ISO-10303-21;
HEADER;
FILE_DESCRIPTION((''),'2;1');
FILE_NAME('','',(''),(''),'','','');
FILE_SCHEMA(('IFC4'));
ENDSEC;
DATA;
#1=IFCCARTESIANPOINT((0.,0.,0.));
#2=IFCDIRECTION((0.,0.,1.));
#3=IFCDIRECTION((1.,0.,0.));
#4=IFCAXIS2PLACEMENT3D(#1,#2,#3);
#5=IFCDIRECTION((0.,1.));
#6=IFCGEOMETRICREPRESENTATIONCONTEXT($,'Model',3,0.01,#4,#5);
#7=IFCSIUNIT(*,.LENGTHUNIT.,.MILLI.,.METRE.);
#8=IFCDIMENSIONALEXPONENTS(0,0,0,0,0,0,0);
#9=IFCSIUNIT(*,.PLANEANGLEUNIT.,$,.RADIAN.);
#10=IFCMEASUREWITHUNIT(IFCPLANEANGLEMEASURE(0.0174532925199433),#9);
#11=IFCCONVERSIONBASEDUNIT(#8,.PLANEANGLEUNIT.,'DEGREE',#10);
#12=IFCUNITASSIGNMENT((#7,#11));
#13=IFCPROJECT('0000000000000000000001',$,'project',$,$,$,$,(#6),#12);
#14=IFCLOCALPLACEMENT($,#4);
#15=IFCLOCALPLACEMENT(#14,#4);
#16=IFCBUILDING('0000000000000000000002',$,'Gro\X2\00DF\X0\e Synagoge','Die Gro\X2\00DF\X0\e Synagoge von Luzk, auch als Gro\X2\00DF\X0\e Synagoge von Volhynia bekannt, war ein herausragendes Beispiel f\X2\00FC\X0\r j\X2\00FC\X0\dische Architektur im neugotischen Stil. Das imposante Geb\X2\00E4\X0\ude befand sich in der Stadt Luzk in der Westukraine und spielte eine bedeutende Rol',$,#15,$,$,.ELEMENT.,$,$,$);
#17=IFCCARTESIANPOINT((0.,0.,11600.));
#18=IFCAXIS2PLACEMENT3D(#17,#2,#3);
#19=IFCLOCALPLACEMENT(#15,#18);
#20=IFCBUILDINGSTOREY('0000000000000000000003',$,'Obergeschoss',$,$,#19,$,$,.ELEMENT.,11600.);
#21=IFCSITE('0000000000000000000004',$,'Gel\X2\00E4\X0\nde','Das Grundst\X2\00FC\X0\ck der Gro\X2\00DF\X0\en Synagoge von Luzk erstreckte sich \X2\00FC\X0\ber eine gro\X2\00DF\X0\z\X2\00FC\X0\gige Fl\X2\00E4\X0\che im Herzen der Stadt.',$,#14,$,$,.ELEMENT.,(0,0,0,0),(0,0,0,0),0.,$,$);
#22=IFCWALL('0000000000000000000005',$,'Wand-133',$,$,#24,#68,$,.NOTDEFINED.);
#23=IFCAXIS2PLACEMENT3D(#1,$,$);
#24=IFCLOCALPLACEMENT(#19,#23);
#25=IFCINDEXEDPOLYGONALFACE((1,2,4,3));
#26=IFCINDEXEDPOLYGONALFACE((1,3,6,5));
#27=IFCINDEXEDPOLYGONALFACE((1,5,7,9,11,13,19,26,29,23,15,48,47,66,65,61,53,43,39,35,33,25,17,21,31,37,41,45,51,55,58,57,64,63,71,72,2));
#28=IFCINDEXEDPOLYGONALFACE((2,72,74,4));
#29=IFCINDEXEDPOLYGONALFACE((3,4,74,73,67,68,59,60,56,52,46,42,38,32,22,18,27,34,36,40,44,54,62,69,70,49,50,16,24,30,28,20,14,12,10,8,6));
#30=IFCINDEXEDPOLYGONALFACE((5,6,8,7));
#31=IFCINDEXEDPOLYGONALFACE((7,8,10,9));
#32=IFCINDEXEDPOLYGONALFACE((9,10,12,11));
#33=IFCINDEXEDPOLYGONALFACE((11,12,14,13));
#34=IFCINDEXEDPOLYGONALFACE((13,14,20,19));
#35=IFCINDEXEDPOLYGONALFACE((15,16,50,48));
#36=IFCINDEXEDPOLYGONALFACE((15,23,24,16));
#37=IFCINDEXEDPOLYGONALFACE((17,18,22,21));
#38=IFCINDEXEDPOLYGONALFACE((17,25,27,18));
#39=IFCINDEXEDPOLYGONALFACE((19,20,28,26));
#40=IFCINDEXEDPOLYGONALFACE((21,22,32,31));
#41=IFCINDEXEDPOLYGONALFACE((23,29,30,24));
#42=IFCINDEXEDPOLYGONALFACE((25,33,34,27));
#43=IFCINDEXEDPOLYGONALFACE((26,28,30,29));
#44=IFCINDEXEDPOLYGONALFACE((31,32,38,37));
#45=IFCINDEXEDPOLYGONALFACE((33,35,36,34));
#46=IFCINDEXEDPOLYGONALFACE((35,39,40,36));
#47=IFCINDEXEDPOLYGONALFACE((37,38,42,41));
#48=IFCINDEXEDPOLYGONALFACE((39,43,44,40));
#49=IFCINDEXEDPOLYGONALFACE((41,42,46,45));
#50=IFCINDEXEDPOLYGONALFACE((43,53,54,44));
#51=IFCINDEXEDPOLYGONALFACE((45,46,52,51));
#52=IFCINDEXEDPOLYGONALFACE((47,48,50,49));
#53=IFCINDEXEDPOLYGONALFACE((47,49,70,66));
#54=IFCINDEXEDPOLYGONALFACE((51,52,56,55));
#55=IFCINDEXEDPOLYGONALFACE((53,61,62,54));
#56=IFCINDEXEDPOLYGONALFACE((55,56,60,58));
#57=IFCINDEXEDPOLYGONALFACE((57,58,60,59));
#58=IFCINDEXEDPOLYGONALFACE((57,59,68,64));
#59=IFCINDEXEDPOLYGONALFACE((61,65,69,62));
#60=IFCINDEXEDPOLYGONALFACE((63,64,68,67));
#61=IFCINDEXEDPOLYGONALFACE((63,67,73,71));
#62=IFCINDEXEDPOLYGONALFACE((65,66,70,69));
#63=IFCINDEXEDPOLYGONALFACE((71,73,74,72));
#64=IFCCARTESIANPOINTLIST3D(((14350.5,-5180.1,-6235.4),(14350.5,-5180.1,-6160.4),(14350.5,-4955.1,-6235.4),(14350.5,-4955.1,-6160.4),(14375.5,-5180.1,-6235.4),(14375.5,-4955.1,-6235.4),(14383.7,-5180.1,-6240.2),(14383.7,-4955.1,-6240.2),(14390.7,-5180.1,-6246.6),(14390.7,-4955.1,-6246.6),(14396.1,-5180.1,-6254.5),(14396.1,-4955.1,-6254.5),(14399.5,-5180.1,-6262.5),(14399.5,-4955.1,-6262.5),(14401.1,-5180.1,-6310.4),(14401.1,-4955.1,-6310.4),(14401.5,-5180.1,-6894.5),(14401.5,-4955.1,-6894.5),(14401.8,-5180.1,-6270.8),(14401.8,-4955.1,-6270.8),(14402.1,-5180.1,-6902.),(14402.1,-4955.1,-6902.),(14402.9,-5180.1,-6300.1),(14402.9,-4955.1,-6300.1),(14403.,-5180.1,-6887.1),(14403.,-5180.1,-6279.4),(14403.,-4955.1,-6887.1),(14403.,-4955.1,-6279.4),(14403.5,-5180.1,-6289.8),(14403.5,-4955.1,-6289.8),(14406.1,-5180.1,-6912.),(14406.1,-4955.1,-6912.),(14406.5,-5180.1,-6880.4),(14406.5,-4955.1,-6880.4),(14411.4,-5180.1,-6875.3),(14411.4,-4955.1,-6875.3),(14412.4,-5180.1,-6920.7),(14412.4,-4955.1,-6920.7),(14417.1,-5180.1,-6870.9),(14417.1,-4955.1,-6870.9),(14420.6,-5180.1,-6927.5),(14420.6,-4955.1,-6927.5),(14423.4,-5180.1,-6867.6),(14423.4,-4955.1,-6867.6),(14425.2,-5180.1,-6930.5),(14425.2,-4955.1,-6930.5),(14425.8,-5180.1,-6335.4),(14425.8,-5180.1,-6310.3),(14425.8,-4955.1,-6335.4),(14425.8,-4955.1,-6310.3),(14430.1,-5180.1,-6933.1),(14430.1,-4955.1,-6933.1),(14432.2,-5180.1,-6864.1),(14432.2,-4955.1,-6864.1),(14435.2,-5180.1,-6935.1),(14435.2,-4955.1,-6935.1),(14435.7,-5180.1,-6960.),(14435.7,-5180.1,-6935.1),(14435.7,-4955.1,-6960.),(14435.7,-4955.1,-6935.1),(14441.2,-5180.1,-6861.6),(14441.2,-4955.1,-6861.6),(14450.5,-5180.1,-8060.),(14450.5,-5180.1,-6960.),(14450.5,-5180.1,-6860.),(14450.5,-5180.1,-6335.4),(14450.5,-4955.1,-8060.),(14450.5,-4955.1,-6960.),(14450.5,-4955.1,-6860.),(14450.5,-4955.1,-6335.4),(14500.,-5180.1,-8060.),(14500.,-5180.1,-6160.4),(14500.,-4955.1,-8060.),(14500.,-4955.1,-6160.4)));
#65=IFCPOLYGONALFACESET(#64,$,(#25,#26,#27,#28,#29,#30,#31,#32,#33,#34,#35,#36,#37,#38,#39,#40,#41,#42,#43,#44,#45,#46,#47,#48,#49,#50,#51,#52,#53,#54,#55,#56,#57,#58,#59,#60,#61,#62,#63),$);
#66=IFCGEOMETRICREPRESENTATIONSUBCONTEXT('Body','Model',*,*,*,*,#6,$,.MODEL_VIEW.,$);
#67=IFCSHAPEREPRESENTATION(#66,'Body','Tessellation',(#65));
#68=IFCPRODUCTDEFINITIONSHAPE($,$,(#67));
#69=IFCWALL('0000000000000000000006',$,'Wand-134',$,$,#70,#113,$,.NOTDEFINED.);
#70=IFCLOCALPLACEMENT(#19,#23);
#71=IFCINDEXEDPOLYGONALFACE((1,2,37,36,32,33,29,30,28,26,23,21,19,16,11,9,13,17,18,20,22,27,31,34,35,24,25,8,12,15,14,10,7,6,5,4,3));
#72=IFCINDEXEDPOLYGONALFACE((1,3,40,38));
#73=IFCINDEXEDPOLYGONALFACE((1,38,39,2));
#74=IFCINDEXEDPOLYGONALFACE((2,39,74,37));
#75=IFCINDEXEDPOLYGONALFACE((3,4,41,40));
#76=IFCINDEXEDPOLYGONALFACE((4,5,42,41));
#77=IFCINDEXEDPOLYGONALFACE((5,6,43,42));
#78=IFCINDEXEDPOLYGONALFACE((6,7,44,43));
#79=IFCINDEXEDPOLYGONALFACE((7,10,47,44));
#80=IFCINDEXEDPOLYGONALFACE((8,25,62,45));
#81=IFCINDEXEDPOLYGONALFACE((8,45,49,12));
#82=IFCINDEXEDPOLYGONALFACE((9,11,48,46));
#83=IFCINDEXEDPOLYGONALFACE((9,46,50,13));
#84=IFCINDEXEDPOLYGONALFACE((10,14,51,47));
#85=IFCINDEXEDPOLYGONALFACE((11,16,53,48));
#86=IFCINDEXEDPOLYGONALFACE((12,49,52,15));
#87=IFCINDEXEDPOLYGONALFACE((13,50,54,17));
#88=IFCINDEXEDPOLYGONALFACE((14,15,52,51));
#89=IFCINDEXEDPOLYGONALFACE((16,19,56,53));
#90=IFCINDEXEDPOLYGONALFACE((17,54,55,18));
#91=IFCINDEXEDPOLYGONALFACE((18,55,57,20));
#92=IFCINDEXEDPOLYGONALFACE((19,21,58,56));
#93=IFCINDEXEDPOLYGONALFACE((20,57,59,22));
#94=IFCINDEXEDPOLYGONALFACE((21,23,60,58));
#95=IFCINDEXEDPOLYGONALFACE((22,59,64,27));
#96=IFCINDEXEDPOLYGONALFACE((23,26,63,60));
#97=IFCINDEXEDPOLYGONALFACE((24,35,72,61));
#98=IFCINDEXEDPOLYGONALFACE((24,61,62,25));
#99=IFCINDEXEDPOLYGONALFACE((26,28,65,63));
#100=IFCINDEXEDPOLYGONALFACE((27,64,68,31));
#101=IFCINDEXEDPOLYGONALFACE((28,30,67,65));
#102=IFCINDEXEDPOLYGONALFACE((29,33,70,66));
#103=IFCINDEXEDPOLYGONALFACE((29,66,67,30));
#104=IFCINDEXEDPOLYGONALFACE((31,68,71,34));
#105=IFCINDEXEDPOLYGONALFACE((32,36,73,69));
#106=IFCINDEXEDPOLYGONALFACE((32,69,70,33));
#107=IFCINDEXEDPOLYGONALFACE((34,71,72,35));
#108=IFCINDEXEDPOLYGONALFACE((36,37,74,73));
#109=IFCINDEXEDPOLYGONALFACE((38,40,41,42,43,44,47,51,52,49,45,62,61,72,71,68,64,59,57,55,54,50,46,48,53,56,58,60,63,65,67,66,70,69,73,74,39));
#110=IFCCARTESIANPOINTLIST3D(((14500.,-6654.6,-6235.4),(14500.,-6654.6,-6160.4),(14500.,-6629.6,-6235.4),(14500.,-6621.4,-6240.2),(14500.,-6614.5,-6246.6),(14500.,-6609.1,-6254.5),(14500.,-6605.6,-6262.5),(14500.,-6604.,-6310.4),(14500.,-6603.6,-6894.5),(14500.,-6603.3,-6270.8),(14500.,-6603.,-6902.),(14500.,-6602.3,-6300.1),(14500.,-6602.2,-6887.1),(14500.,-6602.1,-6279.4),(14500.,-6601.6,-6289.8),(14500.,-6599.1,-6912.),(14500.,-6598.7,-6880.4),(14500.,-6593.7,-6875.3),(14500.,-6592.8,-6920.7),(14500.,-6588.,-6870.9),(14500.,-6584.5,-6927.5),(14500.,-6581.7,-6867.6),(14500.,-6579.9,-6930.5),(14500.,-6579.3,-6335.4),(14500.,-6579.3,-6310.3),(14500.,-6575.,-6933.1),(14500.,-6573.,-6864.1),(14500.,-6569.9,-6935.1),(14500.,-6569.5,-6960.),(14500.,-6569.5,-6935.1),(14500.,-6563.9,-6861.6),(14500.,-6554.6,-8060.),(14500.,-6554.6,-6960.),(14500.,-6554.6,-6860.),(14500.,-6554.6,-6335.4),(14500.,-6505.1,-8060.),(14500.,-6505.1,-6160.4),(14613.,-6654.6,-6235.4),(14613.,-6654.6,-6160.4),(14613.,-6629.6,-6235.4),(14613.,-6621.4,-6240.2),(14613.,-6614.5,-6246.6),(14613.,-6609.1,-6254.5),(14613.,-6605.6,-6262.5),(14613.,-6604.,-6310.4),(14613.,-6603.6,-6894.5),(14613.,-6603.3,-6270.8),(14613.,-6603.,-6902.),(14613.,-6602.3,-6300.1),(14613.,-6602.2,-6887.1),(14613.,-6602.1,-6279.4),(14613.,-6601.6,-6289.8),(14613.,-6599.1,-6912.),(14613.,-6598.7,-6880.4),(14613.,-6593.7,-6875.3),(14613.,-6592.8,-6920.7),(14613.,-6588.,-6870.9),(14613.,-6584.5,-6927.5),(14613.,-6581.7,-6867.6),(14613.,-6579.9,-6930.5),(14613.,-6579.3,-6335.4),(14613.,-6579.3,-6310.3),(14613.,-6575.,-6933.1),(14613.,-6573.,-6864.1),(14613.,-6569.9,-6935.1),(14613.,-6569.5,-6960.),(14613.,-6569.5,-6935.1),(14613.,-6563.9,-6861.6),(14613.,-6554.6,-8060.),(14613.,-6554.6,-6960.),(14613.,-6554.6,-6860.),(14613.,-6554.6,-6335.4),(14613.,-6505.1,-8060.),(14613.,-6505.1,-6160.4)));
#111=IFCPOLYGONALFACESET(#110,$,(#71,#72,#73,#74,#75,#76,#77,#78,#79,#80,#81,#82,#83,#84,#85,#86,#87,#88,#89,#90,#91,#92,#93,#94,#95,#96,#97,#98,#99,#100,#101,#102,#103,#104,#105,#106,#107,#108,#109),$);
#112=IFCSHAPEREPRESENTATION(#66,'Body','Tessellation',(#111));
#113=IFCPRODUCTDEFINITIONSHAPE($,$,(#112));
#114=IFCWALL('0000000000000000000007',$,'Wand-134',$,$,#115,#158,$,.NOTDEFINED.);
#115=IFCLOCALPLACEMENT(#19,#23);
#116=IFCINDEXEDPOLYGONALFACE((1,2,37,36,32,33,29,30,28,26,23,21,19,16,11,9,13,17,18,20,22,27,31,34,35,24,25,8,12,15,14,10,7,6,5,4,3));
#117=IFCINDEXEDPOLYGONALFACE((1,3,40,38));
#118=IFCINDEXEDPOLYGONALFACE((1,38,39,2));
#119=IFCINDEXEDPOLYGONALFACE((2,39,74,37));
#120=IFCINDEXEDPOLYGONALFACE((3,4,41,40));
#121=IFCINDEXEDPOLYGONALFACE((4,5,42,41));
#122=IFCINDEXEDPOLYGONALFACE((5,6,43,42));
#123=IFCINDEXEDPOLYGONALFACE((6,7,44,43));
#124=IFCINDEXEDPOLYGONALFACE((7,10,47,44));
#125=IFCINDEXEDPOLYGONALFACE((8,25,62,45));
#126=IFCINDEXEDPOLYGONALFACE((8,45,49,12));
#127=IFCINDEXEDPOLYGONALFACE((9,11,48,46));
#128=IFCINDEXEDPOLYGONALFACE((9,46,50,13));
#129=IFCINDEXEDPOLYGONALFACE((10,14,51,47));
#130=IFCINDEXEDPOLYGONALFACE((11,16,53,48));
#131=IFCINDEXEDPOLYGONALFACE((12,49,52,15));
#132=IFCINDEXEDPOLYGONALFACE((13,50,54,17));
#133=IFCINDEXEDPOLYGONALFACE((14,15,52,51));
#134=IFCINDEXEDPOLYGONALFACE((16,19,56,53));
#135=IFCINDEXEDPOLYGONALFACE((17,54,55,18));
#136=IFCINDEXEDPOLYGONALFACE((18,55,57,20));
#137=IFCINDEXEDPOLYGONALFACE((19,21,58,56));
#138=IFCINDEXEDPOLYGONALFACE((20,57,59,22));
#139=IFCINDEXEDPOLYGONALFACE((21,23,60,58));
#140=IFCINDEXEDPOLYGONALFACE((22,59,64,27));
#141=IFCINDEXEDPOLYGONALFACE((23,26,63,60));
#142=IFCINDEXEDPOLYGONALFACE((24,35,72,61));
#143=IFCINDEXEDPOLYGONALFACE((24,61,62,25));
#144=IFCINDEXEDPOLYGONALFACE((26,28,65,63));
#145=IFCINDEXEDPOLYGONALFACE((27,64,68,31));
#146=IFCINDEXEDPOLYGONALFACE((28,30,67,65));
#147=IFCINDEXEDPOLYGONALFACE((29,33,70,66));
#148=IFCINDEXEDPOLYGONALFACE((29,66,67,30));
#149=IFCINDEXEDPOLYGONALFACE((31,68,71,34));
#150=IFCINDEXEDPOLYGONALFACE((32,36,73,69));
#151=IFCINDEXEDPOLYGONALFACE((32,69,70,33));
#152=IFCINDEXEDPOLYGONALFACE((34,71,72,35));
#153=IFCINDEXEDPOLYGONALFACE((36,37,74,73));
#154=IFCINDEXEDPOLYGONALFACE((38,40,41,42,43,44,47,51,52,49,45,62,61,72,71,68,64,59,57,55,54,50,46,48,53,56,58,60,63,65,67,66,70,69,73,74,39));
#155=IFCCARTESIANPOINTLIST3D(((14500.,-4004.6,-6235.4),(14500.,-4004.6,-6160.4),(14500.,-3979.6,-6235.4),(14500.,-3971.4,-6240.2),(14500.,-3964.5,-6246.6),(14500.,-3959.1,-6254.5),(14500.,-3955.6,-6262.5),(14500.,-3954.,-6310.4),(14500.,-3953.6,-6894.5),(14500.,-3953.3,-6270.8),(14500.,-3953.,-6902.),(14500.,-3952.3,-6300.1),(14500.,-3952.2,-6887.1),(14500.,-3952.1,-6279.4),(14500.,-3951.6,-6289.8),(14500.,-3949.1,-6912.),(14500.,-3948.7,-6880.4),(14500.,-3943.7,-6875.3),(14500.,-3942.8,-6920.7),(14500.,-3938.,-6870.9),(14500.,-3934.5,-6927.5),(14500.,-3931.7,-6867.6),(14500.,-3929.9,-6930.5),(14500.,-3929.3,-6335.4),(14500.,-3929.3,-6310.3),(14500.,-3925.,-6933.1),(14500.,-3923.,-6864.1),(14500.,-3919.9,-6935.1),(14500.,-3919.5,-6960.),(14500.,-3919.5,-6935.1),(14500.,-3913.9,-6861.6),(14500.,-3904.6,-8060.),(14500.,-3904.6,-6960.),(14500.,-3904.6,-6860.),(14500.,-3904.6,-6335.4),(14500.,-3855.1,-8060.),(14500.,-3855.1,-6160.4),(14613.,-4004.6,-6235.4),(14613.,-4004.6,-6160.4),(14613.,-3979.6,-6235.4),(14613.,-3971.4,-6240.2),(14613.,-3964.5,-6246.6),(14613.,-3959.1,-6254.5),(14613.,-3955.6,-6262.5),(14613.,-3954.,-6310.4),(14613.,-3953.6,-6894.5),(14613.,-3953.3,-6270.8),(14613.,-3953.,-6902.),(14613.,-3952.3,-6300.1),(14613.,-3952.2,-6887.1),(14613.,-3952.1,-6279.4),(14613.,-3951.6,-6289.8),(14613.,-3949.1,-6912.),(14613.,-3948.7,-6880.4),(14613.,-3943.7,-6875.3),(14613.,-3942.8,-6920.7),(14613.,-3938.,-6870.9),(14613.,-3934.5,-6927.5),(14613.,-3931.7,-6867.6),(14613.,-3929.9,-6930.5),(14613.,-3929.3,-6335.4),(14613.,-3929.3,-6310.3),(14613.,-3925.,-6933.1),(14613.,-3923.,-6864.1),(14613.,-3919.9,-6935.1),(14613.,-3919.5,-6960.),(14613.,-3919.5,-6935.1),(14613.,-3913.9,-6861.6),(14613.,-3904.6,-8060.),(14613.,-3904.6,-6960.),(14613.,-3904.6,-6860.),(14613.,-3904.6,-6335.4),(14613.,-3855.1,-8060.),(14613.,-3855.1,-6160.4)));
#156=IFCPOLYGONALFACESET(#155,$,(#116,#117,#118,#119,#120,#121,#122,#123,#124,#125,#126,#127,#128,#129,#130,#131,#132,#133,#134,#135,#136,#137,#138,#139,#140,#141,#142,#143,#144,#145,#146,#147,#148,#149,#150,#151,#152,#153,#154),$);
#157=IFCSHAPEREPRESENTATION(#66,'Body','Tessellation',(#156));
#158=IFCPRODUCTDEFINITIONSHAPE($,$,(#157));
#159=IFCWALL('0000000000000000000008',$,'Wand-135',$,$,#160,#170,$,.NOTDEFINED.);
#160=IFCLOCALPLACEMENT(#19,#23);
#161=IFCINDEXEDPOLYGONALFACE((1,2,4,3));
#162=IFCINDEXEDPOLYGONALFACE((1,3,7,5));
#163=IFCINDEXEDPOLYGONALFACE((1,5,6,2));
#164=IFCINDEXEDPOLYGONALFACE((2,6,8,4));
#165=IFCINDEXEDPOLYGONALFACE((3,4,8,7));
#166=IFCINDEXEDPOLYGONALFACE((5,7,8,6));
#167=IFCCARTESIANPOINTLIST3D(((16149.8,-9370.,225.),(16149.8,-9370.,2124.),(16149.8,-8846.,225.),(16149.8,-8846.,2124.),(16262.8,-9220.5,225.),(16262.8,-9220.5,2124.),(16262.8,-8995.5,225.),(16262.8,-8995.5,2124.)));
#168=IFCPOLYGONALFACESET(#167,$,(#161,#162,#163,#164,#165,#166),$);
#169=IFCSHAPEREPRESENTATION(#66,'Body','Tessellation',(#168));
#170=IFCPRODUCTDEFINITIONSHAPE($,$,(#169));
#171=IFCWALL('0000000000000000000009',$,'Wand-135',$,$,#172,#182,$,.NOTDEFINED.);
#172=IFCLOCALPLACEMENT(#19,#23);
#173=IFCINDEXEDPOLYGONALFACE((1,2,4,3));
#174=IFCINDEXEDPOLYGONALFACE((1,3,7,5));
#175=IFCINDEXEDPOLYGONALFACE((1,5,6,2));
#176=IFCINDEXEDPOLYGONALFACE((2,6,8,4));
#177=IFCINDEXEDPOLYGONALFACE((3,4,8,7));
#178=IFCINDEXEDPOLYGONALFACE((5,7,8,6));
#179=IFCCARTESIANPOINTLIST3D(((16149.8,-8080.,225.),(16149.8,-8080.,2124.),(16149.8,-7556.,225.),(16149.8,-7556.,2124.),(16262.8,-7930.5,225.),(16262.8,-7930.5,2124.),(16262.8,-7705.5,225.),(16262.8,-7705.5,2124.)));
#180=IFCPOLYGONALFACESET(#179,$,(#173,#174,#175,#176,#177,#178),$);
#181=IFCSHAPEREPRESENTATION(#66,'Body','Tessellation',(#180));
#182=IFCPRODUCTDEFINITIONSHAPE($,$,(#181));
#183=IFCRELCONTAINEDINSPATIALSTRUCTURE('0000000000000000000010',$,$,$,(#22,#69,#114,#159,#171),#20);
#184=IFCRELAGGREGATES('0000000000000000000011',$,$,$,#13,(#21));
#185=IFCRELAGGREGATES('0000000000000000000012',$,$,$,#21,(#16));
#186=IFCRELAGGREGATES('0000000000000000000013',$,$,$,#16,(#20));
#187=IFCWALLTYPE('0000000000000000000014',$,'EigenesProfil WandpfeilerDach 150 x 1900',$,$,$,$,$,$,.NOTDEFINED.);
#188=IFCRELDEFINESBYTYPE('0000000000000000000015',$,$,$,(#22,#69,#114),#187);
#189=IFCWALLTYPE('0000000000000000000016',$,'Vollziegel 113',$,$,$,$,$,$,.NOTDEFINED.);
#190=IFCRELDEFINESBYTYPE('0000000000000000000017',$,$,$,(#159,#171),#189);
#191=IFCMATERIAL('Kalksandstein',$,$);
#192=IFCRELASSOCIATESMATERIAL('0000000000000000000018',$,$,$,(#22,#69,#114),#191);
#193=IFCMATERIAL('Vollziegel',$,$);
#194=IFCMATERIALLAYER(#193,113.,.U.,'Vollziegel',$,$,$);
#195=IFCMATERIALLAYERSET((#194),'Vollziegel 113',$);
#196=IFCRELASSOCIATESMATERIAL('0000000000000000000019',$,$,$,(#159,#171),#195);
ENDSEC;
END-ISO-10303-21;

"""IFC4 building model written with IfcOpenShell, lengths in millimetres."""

from ifc_helpers import new_model, entity, si_unit, converted_unit, direction, frame, origin_with_axes, place, context, subcontext, project, spatial, line, arc, indexed_curve, outline, extrude, material, layer, layer_set, layer_usage, material_profile, profile_set, type_object, element, save


model = new_model("IFC4")

# Units and contexts
model_context = context("Model", 3, precision=0.01, world=origin_with_axes(), true_north=direction((0.0, 1.0)))
body_context = subcontext(model_context, "Body", "Model", "MODEL_VIEW")
ifc_project = project(units=[si_unit("LENGTHUNIT", "METRE", prefix="MILLI"), converted_unit("PLANEANGLEUNIT", "DEGREE", entity("IfcPlaneAngleMeasure", 0.0174532925199433), si_unit("PLANEANGLEUNIT", "RADIAN"), dimensions=[0, 0, 0, 0, 0, 0, 0])], contexts=[model_context])

# Site, building, storey
site_placement = place(None, origin_with_axes())
site = spatial("IfcSite", under=ifc_project, at=site_placement, Name="Gelände", Description="Das Grundstück der Großen Synagoge von Luzk erstreckte sich über eine großzügige Fläche im Herzen der Stadt.", CompositionType="ELEMENT", RefLatitude=(0, 0, 0, 0), RefLongitude=(0, 0, 0, 0), RefElevation=0.0)
building_placement = place(site_placement, origin_with_axes())
building = spatial("IfcBuilding", under=site, at=building_placement, Name="Große Synagoge", Description="Die Große Synagoge von Luzk, auch als Große Synagoge von Volhynia bekannt, war ein herausragendes Beispiel für jüdische Architektur im neugotischen Stil. Das imposante Gebäude befand sich in der Stadt Luzk in der Westukraine und spielte eine bedeutende Rol", CompositionType="ELEMENT")
storey_placement = place(building_placement, frame((0.0, 0.0, 11600.0), z_axis=(0.0, 0.0, 1.0), x_axis=(1.0, 0.0, 0.0)))
storey = spatial("IfcBuildingStorey", under=building, at=storey_placement, Name="Obergeschoss", CompositionType="ELEMENT", Elevation=11600.0)

# Walls
ifc_material_1 = material(Name="Kalksandstein")
ifc_material_profile = material_profile(ifc_material_1, outline(indexed_curve([(74.2, 1749.6), (98.9, 1749.6), (96.7, 1765.0), (97.0, 1780.5), (99.2, 1793.4), (103.9, 1805.5), (112.6, 1816.7), (124.5, 1824.6), (149.5, 1824.6), (149.5, 1899.6), (0.0, 1899.6), (0.0, 0.0), (49.5, 0.0), (49.5, 1100.0), (64.3, 1100.0), (64.3, 1124.9), (64.8, 1124.9), (72.4, 1128.1), (79.4, 1132.4), (91.1, 1143.4), (97.9, 1157.9), (98.0, 1169.2), (93.5, 1179.5), (85.8, 1187.0), (76.6, 1192.3), (63.3, 1197.2), (49.5, 1200.0), (49.5, 1724.6), (74.2, 1724.6)], segments=[line(1, 2), arc(2, 3, 4), arc(4, 5, 6), arc(6, 7, 8), line(8, 9, 10, 11, 12, 13, 14, 15, 16, 17), arc(17, 18, 19), arc(19, 20, 21), arc(21, 22, 23), arc(23, 24, 25), arc(25, 26, 27), line(27, 28, 29, 1)])), Name="Kalksandstein")
ifc_profile_set = profile_set([ifc_material_profile], Name="EigenesProfil WandpfeilerDach")
wall_type_1 = type_object("IfcWallType", Name="EigenesProfil WandpfeilerDach 150 x 1900", PredefinedType="NOTDEFINED")
wall_1_placement = place(storey_placement, frame((14500.0, -4955.1, -8060.0), z_axis=(0.0, 0.0, 1.0), x_axis=(0.0, -1.0, 0.0)))
element("IfcWall", 1, at=wall_1_placement, inside=storey, type_object=wall_type_1, material=ifc_profile_set, Name="Wand-133", PredefinedType="NOTDEFINED", context=body_context, shape_type="SweptSolid", body=[
    extrude(outline(indexed_curve([(74.2, 1749.6), (98.9, 1749.6), (96.7, 1765.0), (97.0, 1780.5), (99.2, 1793.4), (103.9, 1805.5), (112.6, 1816.7), (124.5, 1824.6), (149.5, 1824.6), (149.5, 1899.6), (0.0, 1899.6), (0.0, 0.0), (49.5, 0.0), (49.5, 1100.0), (64.3, 1100.0), (64.3, 1124.9), (64.8, 1124.9), (72.4, 1128.1), (79.4, 1132.4), (91.1, 1143.4), (97.9, 1157.9), (98.0, 1169.2), (93.5, 1179.5), (85.8, 1187.0), (76.6, 1192.3), (63.3, 1197.2), (49.5, 1200.0), (49.5, 1724.6), (74.2, 1724.6)], segments=[line(1, 2), arc(2, 3, 4), arc(4, 5, 6), arc(6, 7, 8), line(8, 9, 10, 11, 12, 13, 14, 15, 16, 17), arc(17, 18, 19), arc(19, 20, 21), arc(21, 22, 23), arc(23, 24, 25), arc(25, 26, 27), line(27, 28, 29, 1)])), frame((0.0, 0.0, 0.0), z_axis=(-1.0, 0.0, 0.0), x_axis=(0.0, -1.0, 0.0)), (0.0, 0.0, -1.0), 225.0),
])
for number, where, z_axis, x_axis, name in (
    (2, (14500.0, -6505.1, -8060.0), (0.0, 0.0, 1.0), (1.0, 0.0, 0.0), "Wand-134"),
    (3, (14500.0, -3855.1, -8060.0), (0.0, 0.0, 1.0), (1.0, 0.0, 0.0), "Wand-134"),
):
    element("IfcWall", number, at=place(storey_placement, frame(where, z_axis=z_axis, x_axis=x_axis)), inside=storey, type_object=wall_type_1, material=ifc_profile_set, Name=name, PredefinedType="NOTDEFINED", context=body_context, shape_type="SweptSolid", body=[
        extrude(outline(indexed_curve([(74.2, 1749.6), (98.9, 1749.6), (96.7, 1765.0), (97.0, 1780.5), (99.2, 1793.4), (103.9, 1805.5), (112.6, 1816.7), (124.5, 1824.6), (149.5, 1824.6), (149.5, 1899.6), (0.0, 1899.6), (0.0, 0.0), (49.5, 0.0), (49.5, 1100.0), (64.3, 1100.0), (64.3, 1124.9), (64.8, 1124.9), (72.4, 1128.1), (79.4, 1132.4), (91.1, 1143.4), (97.9, 1157.9), (98.0, 1169.2), (93.5, 1179.5), (85.8, 1187.0), (76.6, 1192.3), (63.3, 1197.2), (49.5, 1200.0), (49.5, 1724.6), (74.2, 1724.6)], segments=[line(1, 2), arc(2, 3, 4), arc(4, 5, 6), arc(6, 7, 8), line(8, 9, 10, 11, 12, 13, 14, 15, 16, 17), arc(17, 18, 19), arc(19, 20, 21), arc(21, 22, 23), arc(23, 24, 25), arc(25, 26, 27), line(27, 28, 29, 1)])), frame((0.0, 0.0, 0.0), z_axis=(-1.0, 0.0, 0.0), x_axis=(0.0, -1.0, 0.0)), (0.0, 0.0, -1.0), 113.0),
    ])
ifc_material_2 = material(Name="Vollziegel")
ifc_layer = layer(ifc_material_2, 113.0, ventilated="UNKNOWN", Name="Vollziegel")
ifc_layer_set = layer_set([ifc_layer], Name="Vollziegel 113")
ifc_layer_usage_1 = layer_usage(ifc_layer_set, "AXIS2", "NEGATIVE", 113.0)
wall_type_2 = type_object("IfcWallType", Name="Vollziegel 113", PredefinedType="NOTDEFINED")
wall_2_placement = place(storey_placement, frame((16149.8, -8995.5, 225.0), z_axis=(0.0, 0.0, 1.0), x_axis=(-0.000019, -1.0, 0.0)))
element("IfcWall", 4, at=wall_2_placement, inside=storey, type_object=wall_type_2, material=ifc_layer_usage_1, Name="Wand-135", PredefinedType="NOTDEFINED", context=body_context, shape_type="SweptSolid", body=[
    extrude(outline(indexed_curve([(-149.5, 0.0), (374.5, 0.0), (225.0, 113.0), (0.0, 113.0)], segments=[line(1, 2, 3, 4, 1)])), origin_with_axes(), (0.0, 0.0, 1.0), 1899.0),
])
ifc_layer_usage_2 = layer_usage(ifc_layer_set, "AXIS2", "NEGATIVE", 113.0)
wall_3_placement = place(storey_placement, frame((16149.8, -7705.5, 225.0), z_axis=(0.0, 0.0, 1.0), x_axis=(-0.000019, -1.0, 0.0)))
element("IfcWall", 5, at=wall_3_placement, inside=storey, type_object=wall_type_2, material=ifc_layer_usage_2, Name="Wand-135", PredefinedType="NOTDEFINED", context=body_context, shape_type="SweptSolid", body=[
    extrude(outline(indexed_curve([(-149.5, 0.0), (374.5, 0.0), (225.0, 113.0), (0.0, 113.0)], segments=[line(1, 2, 3, 4, 1)])), origin_with_axes(), (0.0, 0.0, 1.0), 1899.0),
])

save(model, "model.ifc")
